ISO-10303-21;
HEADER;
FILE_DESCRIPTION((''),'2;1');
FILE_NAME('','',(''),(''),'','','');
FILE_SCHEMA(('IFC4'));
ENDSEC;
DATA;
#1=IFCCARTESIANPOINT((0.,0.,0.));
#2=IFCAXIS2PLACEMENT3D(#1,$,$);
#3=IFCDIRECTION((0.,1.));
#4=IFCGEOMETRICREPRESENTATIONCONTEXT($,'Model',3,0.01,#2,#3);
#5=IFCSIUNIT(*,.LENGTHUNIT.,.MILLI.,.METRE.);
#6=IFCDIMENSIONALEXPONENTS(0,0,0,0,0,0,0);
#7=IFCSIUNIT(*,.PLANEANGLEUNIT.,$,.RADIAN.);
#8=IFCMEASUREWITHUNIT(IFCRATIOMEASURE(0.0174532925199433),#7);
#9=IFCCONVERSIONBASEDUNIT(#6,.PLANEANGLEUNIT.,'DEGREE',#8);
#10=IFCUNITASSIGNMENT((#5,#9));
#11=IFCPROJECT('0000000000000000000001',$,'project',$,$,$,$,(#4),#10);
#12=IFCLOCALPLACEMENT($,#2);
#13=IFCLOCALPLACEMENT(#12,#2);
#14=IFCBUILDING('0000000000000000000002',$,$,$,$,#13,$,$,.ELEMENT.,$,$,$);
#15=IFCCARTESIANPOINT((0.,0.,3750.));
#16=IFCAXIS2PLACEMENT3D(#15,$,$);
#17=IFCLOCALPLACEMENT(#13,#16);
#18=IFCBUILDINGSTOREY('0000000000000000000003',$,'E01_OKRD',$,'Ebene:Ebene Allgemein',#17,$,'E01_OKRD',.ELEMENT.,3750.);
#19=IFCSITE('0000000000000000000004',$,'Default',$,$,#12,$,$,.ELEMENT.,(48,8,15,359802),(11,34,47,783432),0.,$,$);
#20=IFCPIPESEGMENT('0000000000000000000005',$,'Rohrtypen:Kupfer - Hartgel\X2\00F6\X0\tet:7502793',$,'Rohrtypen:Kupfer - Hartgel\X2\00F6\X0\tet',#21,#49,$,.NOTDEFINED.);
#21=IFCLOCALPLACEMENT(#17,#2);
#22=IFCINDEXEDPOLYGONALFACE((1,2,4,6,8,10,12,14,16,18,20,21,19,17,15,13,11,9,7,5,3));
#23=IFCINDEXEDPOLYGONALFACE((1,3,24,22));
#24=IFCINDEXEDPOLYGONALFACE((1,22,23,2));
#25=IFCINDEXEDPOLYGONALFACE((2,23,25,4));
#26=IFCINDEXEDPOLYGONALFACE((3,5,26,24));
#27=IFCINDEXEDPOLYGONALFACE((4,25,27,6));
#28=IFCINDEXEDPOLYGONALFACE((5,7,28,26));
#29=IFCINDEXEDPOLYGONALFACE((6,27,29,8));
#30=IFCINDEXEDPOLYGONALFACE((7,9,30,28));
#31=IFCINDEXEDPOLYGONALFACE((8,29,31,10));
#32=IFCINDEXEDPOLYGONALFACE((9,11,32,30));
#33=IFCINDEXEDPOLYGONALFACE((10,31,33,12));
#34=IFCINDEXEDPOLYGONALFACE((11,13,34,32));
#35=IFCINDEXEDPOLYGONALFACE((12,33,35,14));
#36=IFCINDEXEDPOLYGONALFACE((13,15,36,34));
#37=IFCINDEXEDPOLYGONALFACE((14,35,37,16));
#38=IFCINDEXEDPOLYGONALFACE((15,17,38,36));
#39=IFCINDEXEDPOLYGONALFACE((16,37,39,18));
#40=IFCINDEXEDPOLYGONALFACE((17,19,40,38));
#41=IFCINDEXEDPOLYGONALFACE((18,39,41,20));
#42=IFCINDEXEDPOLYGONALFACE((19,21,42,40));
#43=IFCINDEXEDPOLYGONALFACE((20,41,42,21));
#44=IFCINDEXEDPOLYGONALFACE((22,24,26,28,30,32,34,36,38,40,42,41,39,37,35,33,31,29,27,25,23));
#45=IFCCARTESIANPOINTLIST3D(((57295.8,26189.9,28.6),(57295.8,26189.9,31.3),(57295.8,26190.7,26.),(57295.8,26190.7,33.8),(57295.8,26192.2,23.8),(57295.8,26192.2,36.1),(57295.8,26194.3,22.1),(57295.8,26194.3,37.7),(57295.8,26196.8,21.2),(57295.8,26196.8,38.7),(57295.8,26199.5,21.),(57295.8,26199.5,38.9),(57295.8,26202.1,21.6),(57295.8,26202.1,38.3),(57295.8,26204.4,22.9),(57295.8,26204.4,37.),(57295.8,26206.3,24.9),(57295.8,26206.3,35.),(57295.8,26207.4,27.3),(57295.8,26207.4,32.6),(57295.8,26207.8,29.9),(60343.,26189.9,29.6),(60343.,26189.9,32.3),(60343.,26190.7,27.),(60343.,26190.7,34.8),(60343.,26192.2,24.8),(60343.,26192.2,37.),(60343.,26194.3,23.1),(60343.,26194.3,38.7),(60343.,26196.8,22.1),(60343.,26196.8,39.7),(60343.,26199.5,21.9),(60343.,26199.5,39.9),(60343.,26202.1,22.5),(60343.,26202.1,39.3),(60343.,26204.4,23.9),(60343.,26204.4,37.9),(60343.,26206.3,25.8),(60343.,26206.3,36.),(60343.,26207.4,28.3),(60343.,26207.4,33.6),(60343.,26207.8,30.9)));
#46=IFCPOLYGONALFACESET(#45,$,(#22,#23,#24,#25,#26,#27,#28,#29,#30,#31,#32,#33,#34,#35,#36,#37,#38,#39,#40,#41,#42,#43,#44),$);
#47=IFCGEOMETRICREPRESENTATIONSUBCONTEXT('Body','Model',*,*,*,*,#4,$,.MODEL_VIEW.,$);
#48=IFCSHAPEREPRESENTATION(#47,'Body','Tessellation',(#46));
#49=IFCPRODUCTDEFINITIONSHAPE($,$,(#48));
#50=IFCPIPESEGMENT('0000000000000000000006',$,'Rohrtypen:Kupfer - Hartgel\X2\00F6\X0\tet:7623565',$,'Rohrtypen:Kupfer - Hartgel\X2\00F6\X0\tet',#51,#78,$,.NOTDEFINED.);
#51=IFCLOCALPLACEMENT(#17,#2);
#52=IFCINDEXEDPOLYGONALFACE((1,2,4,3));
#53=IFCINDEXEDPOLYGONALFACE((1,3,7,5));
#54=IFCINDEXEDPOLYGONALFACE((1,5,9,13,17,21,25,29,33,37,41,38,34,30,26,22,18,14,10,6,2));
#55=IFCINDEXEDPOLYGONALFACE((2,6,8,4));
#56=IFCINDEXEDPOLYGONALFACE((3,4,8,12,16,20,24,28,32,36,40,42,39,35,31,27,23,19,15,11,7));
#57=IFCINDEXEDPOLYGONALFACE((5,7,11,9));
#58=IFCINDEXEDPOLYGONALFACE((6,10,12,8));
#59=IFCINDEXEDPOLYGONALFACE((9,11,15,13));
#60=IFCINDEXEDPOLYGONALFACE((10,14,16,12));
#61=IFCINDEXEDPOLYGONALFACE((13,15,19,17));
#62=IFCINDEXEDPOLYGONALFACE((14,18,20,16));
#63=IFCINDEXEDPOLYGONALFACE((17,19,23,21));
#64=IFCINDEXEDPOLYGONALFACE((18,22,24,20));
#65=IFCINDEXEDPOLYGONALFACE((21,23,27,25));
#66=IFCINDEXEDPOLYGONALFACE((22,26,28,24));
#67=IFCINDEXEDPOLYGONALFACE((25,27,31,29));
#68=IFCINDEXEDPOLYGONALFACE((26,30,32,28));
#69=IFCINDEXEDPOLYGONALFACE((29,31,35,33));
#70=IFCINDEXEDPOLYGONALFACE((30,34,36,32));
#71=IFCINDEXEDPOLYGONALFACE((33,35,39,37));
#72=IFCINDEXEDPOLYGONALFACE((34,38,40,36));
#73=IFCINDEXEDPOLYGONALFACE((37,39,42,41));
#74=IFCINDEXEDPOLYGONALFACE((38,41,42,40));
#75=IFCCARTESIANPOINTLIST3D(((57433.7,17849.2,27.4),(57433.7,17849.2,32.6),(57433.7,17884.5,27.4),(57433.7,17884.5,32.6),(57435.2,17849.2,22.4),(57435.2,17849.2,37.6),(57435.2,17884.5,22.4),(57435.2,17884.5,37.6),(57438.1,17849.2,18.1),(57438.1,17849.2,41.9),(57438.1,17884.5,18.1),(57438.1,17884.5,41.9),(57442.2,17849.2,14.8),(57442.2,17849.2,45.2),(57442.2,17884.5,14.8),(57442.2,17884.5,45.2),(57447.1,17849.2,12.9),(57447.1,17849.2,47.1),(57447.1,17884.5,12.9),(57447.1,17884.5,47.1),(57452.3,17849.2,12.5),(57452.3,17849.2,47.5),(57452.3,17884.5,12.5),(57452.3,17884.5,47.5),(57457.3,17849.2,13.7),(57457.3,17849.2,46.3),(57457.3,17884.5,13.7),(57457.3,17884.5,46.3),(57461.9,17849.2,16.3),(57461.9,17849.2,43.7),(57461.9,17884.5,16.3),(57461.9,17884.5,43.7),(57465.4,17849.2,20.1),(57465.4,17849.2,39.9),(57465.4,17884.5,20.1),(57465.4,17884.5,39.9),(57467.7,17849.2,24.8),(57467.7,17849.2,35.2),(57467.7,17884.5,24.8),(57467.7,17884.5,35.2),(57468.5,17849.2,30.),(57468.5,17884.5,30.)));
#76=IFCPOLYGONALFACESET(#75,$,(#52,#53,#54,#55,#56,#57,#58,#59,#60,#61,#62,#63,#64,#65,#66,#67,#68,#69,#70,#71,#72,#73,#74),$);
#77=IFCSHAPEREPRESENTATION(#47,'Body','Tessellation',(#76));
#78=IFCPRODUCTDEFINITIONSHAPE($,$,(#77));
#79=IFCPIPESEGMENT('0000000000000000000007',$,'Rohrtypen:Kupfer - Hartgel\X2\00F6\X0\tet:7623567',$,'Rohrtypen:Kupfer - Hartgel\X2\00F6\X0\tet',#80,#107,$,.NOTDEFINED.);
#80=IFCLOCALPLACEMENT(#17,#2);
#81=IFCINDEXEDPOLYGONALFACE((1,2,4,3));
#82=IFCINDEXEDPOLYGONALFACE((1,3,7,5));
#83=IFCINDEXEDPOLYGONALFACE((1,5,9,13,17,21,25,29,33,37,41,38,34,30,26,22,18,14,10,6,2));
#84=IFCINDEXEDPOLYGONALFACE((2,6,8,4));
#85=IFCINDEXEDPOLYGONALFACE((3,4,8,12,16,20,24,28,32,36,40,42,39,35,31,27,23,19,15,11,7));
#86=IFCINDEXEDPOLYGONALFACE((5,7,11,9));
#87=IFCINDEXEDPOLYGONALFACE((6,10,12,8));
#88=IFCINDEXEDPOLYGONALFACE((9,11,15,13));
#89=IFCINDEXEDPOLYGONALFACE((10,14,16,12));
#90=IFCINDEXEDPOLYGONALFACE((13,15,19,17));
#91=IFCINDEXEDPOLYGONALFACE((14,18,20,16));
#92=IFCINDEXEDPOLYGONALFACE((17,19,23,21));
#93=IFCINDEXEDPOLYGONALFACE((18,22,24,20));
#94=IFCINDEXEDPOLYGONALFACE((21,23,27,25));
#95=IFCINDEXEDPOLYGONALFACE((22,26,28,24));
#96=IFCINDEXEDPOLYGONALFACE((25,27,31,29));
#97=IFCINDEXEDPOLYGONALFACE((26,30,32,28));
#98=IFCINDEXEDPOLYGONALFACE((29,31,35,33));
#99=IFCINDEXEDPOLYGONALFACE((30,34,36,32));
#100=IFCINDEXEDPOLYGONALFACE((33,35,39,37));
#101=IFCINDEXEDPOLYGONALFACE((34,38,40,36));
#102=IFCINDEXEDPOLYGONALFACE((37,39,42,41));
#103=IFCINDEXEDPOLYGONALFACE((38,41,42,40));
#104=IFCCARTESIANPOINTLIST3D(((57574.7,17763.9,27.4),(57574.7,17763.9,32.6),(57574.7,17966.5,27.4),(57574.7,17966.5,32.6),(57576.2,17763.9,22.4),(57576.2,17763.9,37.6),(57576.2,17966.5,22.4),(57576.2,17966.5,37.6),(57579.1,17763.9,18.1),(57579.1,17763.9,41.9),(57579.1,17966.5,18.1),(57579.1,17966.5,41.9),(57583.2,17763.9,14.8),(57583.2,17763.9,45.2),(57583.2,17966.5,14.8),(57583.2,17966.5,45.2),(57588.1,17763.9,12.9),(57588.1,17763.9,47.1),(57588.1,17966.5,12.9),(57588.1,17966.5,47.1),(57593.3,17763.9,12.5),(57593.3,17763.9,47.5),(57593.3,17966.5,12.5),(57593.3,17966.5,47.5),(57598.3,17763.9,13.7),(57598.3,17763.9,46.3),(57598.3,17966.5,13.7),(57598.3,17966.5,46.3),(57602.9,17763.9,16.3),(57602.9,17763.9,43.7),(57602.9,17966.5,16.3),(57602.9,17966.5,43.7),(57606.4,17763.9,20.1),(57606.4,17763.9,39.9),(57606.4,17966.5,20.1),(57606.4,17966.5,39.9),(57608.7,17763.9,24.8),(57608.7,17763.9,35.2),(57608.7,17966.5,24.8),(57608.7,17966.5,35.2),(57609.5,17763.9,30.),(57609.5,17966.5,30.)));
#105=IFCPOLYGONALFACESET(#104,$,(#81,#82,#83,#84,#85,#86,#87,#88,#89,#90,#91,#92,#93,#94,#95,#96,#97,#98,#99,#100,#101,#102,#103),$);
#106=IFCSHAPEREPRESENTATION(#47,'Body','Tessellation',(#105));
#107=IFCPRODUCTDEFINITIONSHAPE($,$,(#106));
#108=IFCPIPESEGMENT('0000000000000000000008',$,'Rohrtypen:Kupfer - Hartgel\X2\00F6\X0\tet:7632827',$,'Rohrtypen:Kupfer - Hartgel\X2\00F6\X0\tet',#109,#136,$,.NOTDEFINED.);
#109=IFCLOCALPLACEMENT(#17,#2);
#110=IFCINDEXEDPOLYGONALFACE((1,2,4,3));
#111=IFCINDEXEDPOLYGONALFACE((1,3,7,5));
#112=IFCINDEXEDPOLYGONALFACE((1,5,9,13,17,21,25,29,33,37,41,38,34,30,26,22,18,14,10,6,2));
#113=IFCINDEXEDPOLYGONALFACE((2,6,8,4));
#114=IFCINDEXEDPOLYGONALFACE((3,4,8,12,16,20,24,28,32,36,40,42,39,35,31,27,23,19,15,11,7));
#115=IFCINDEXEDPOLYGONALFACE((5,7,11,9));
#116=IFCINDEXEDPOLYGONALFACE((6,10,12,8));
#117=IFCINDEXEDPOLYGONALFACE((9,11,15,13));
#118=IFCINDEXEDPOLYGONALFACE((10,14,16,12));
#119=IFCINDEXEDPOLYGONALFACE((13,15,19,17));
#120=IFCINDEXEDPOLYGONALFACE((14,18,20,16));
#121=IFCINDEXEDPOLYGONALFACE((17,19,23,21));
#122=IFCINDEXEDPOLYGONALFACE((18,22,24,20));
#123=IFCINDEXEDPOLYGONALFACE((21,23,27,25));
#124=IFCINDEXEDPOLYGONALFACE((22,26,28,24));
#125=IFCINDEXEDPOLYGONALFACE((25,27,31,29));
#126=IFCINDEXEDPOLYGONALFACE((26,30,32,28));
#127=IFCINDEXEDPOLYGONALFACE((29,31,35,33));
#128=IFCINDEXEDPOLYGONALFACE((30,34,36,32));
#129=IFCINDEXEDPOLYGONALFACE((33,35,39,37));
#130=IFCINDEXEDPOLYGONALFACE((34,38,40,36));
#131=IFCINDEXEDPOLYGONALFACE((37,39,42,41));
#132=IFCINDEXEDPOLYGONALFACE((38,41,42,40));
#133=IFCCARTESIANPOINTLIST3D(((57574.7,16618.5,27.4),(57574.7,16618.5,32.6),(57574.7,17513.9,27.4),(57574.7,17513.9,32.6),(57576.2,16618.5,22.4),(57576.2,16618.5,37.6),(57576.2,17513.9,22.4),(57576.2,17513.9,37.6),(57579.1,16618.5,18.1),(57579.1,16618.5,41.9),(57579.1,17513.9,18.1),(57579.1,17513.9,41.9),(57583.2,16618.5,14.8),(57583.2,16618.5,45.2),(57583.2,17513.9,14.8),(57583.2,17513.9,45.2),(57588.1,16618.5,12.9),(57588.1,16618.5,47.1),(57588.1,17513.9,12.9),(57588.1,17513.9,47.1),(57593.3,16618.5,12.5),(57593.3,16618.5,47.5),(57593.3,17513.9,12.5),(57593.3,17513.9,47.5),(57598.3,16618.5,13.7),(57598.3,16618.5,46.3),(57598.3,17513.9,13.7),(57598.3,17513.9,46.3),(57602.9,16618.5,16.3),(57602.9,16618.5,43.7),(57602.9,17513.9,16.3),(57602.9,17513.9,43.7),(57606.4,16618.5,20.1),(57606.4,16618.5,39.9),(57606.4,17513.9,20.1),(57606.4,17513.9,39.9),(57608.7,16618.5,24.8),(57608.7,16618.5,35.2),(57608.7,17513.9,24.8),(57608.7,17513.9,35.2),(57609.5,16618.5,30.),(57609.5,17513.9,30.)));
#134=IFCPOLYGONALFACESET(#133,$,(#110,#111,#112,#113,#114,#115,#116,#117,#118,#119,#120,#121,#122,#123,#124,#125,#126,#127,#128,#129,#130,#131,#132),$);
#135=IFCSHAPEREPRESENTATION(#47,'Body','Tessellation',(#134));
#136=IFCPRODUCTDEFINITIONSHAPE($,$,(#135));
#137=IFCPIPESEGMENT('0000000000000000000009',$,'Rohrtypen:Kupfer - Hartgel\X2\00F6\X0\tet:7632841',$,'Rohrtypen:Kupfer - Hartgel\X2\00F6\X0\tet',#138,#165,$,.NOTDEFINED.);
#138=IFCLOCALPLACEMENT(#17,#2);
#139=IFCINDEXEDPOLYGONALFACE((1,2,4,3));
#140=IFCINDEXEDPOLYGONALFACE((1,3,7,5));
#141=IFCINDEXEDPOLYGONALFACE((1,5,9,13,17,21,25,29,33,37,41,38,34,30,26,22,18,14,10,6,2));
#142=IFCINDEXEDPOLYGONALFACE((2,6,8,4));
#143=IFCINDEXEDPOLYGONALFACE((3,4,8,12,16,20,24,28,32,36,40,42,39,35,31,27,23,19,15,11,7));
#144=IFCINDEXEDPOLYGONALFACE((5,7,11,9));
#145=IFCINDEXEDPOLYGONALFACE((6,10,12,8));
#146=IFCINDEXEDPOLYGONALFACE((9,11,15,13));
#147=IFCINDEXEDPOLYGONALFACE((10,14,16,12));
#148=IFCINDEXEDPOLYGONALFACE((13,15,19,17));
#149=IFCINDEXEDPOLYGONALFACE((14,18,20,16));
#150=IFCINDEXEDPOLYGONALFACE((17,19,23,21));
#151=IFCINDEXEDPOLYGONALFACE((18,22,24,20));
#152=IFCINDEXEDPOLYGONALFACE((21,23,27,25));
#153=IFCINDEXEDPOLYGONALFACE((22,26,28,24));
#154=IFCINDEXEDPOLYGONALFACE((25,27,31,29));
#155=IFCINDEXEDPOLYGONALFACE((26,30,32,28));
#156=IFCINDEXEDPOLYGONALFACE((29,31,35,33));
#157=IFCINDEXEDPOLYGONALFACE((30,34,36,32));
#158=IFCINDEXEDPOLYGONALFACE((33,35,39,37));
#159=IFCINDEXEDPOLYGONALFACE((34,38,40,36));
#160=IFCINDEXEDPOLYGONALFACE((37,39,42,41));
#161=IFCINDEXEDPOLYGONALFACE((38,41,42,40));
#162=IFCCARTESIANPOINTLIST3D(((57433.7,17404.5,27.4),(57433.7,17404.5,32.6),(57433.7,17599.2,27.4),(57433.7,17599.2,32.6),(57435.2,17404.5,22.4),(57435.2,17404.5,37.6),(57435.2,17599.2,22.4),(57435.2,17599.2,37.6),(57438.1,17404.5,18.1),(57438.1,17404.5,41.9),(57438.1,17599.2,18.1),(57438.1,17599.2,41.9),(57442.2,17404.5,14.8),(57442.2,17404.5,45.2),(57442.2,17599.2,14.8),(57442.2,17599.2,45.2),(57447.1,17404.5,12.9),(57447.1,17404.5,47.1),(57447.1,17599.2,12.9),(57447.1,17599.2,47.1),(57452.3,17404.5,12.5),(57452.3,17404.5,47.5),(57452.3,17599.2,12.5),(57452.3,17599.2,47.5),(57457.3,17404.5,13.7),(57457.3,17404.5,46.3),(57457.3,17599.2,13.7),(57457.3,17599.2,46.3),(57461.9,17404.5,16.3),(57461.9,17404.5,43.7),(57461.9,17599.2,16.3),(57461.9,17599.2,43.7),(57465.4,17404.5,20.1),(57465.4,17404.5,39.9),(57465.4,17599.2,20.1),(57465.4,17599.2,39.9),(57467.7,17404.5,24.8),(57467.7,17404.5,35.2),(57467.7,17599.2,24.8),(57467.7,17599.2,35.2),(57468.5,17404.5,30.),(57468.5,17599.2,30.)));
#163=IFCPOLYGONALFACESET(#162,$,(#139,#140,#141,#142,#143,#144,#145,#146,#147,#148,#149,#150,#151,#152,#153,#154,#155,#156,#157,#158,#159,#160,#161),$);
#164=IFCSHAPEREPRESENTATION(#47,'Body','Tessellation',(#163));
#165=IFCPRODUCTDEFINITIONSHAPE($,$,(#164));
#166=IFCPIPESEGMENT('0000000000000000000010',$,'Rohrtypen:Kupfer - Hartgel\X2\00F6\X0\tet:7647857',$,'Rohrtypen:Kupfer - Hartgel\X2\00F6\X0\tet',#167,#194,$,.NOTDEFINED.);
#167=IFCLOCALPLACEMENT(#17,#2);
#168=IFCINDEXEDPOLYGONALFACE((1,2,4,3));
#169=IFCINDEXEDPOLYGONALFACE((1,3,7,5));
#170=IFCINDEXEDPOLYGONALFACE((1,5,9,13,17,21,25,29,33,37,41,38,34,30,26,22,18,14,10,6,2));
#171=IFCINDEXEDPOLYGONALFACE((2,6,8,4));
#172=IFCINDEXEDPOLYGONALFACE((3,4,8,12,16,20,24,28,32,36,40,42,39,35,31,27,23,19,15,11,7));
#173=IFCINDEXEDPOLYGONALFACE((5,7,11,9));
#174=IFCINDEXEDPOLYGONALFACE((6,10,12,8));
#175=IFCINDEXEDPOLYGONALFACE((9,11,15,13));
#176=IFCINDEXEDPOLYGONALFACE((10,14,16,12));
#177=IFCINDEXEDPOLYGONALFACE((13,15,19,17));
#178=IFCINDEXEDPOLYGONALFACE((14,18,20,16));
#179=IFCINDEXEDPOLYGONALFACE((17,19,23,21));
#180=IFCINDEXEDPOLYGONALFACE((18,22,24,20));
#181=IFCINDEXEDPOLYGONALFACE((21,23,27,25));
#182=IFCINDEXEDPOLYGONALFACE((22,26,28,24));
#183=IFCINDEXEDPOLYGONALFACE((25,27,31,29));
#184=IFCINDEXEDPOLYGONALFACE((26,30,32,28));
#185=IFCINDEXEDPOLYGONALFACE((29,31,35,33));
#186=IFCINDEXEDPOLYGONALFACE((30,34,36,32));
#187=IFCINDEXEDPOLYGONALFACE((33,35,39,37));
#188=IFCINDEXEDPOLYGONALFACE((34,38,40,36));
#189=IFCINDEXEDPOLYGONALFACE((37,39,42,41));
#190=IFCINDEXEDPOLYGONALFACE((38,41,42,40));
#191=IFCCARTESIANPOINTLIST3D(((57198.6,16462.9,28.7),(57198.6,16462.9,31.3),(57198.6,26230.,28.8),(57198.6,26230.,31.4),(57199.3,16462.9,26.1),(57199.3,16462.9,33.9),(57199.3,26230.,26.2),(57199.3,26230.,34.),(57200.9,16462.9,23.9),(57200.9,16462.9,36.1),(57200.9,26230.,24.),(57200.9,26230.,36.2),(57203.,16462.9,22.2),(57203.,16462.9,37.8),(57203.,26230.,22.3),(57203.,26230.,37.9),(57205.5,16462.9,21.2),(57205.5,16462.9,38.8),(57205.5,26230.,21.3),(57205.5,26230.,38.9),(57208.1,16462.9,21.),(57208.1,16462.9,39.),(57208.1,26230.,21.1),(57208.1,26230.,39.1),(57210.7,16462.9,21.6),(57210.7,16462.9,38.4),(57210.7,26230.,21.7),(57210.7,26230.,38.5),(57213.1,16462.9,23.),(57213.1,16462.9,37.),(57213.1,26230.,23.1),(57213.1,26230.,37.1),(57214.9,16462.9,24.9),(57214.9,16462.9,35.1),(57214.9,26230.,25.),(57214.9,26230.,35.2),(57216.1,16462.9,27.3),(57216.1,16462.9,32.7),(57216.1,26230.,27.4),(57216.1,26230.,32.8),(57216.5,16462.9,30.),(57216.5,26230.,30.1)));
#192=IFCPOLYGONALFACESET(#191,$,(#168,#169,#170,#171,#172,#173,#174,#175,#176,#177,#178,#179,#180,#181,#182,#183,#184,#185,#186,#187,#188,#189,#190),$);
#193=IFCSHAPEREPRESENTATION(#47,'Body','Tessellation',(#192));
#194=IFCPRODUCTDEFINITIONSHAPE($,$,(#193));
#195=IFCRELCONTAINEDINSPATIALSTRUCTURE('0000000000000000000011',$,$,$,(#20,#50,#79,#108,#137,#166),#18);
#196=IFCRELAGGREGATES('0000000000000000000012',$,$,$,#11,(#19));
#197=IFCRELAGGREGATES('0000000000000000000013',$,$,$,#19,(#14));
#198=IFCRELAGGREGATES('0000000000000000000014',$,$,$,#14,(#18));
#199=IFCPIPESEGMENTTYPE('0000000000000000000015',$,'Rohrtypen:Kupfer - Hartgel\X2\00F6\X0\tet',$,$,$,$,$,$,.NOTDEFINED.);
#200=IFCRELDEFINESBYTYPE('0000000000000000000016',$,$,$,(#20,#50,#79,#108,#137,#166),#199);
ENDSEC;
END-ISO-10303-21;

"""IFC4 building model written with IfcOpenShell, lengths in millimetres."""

from ifc_helpers import new_model, entity, si_unit, converted_unit, direction, frame, frame_2d, origin, origin_2d_with_axis, place, context, subcontext, project, spatial, circle, extrude, type_object, element, save


model = new_model("IFC4")

# Units and contexts
model_context = context("Model", 3, precision=0.01, world=origin(), true_north=direction((0.0, 1.0)))
body_context = subcontext(model_context, "Body", "Model", "MODEL_VIEW")
ifc_project = project(units=[si_unit("LENGTHUNIT", "METRE", prefix="MILLI"), converted_unit("PLANEANGLEUNIT", "DEGREE", entity("IfcRatioMeasure", 0.0174532925199433), si_unit("PLANEANGLEUNIT", "RADIAN"), dimensions=[0, 0, 0, 0, 0, 0, 0])], contexts=[model_context])

# Site, building, storey
site_placement = place(None, origin())
site = spatial("IfcSite", under=ifc_project, at=site_placement, Name="Default", CompositionType="ELEMENT", RefLatitude=(48, 8, 15, 359802), RefLongitude=(11, 34, 47, 783432), RefElevation=0.0)
building_placement = place(site_placement, origin())
building = spatial("IfcBuilding", under=site, at=building_placement, CompositionType="ELEMENT")
storey_placement = place(building_placement, frame((0.0, 0.0, 3750.0)))
storey = spatial("IfcBuildingStorey", under=building, at=storey_placement, Name="E01_OKRD", ObjectType="Ebene:Ebene Allgemein", LongName="E01_OKRD", CompositionType="ELEMENT", Elevation=3750.0)

# Pipe segments
pipe_segment_type = type_object("IfcPipeSegmentType", Name="Rohrtypen:Kupfer - Hartgelötet", PredefinedType="NOTDEFINED")
pipe_segment_1_placement = place(storey_placement, frame((57295.8, 26188.2, 19.3)))
element("IfcPipeSegment", 1, at=pipe_segment_1_placement, inside=storey, type_object=pipe_segment_type, Name="Rohrtypen:Kupfer - Hartgelötet:7502793", ObjectType="Rohrtypen:Kupfer - Hartgelötet", PredefinedType="NOTDEFINED", context=body_context, shape_type="SweptSolid", body=[
    extrude(circle(Radius=9.0, at=origin_2d_with_axis()), frame((0.0, 10.6, 10.6), z_axis=(1.0, 0.0, 0.000319), x_axis=(0.0, 1.0, 0.0)), (0.0, 0.0, 1.0), 3047.2),
])
pipe_segment_2_placement = place(storey_placement, frame((57431.9, 17849.2, 10.9)))
element("IfcPipeSegment", 2, at=pipe_segment_2_placement, inside=storey, type_object=pipe_segment_type, Name="Rohrtypen:Kupfer - Hartgelötet:7623565", ObjectType="Rohrtypen:Kupfer - Hartgelötet", PredefinedType="NOTDEFINED", context=body_context, shape_type="SweptSolid", body=[
    extrude(circle(Radius=17.5, at=origin_2d_with_axis()), frame((19.1, 0.0, 19.1), z_axis=(0.0, 1.0, 0.0), x_axis=(1.0, 0.0, 0.0)), (0.0, 0.0, 1.0), 35.3),
])
pipe_segment_3_placement = place(storey_placement, frame((57572.9, 17763.9, 10.9)))
element("IfcPipeSegment", 3, at=pipe_segment_3_placement, inside=storey, type_object=pipe_segment_type, Name="Rohrtypen:Kupfer - Hartgelötet:7623567", ObjectType="Rohrtypen:Kupfer - Hartgelötet", PredefinedType="NOTDEFINED", context=body_context, shape_type="SweptSolid", body=[
    extrude(circle(Radius=17.5, at=frame_2d((0.0, 0.0), x_axis=(1.0, 0.0))), frame((19.1, 0.0, 19.1), z_axis=(0.0, 1.0, 0.0), x_axis=(1.0, 0.0, 0.0)), (0.0, 0.0, 1.0), 202.6),
])
pipe_segment_4_placement = place(storey_placement, frame((57572.9, 16618.5, 10.9)))
element("IfcPipeSegment", 4, at=pipe_segment_4_placement, inside=storey, type_object=pipe_segment_type, Name="Rohrtypen:Kupfer - Hartgelötet:7632827", ObjectType="Rohrtypen:Kupfer - Hartgelötet", PredefinedType="NOTDEFINED", context=body_context, shape_type="SweptSolid", body=[
    extrude(circle(Radius=17.5, at=frame_2d((0.0, 0.0), x_axis=(1.0, 0.0))), frame((19.1, 0.0, 19.1), z_axis=(0.0, 1.0, 0.0), x_axis=(1.0, 0.0, 0.0)), (0.0, 0.0, 1.0), 895.4),
])
pipe_segment_5_placement = place(storey_placement, frame((57431.9, 17404.5, 10.9)))
element("IfcPipeSegment", 5, at=pipe_segment_5_placement, inside=storey, type_object=pipe_segment_type, Name="Rohrtypen:Kupfer - Hartgelötet:7632841", ObjectType="Rohrtypen:Kupfer - Hartgelötet", PredefinedType="NOTDEFINED", context=body_context, shape_type="SweptSolid", body=[
    extrude(circle(Radius=17.5, at=origin_2d_with_axis()), frame((19.1, 0.0, 19.1), z_axis=(0.0, 1.0, 0.0), x_axis=(1.0, 0.0, 0.0)), (0.0, 0.0, 1.0), 194.8),
])
pipe_segment_6_placement = place(storey_placement, frame((57196.9, 16462.9, 19.4)))
element("IfcPipeSegment", 6, at=pipe_segment_6_placement, inside=storey, type_object=pipe_segment_type, Name="Rohrtypen:Kupfer - Hartgelötet:7647857", ObjectType="Rohrtypen:Kupfer - Hartgelötet", PredefinedType="NOTDEFINED", context=body_context, shape_type="SweptSolid", body=[
    extrude(circle(Radius=9.0, at=origin_2d_with_axis()), frame((10.6, 0.0, 10.6), z_axis=(0.0, 1.0, 0.00001), x_axis=(1.0, 0.0, 0.0)), (0.0, 0.0, 1.0), 9767.1),
])

save(model, "model.ifc")
